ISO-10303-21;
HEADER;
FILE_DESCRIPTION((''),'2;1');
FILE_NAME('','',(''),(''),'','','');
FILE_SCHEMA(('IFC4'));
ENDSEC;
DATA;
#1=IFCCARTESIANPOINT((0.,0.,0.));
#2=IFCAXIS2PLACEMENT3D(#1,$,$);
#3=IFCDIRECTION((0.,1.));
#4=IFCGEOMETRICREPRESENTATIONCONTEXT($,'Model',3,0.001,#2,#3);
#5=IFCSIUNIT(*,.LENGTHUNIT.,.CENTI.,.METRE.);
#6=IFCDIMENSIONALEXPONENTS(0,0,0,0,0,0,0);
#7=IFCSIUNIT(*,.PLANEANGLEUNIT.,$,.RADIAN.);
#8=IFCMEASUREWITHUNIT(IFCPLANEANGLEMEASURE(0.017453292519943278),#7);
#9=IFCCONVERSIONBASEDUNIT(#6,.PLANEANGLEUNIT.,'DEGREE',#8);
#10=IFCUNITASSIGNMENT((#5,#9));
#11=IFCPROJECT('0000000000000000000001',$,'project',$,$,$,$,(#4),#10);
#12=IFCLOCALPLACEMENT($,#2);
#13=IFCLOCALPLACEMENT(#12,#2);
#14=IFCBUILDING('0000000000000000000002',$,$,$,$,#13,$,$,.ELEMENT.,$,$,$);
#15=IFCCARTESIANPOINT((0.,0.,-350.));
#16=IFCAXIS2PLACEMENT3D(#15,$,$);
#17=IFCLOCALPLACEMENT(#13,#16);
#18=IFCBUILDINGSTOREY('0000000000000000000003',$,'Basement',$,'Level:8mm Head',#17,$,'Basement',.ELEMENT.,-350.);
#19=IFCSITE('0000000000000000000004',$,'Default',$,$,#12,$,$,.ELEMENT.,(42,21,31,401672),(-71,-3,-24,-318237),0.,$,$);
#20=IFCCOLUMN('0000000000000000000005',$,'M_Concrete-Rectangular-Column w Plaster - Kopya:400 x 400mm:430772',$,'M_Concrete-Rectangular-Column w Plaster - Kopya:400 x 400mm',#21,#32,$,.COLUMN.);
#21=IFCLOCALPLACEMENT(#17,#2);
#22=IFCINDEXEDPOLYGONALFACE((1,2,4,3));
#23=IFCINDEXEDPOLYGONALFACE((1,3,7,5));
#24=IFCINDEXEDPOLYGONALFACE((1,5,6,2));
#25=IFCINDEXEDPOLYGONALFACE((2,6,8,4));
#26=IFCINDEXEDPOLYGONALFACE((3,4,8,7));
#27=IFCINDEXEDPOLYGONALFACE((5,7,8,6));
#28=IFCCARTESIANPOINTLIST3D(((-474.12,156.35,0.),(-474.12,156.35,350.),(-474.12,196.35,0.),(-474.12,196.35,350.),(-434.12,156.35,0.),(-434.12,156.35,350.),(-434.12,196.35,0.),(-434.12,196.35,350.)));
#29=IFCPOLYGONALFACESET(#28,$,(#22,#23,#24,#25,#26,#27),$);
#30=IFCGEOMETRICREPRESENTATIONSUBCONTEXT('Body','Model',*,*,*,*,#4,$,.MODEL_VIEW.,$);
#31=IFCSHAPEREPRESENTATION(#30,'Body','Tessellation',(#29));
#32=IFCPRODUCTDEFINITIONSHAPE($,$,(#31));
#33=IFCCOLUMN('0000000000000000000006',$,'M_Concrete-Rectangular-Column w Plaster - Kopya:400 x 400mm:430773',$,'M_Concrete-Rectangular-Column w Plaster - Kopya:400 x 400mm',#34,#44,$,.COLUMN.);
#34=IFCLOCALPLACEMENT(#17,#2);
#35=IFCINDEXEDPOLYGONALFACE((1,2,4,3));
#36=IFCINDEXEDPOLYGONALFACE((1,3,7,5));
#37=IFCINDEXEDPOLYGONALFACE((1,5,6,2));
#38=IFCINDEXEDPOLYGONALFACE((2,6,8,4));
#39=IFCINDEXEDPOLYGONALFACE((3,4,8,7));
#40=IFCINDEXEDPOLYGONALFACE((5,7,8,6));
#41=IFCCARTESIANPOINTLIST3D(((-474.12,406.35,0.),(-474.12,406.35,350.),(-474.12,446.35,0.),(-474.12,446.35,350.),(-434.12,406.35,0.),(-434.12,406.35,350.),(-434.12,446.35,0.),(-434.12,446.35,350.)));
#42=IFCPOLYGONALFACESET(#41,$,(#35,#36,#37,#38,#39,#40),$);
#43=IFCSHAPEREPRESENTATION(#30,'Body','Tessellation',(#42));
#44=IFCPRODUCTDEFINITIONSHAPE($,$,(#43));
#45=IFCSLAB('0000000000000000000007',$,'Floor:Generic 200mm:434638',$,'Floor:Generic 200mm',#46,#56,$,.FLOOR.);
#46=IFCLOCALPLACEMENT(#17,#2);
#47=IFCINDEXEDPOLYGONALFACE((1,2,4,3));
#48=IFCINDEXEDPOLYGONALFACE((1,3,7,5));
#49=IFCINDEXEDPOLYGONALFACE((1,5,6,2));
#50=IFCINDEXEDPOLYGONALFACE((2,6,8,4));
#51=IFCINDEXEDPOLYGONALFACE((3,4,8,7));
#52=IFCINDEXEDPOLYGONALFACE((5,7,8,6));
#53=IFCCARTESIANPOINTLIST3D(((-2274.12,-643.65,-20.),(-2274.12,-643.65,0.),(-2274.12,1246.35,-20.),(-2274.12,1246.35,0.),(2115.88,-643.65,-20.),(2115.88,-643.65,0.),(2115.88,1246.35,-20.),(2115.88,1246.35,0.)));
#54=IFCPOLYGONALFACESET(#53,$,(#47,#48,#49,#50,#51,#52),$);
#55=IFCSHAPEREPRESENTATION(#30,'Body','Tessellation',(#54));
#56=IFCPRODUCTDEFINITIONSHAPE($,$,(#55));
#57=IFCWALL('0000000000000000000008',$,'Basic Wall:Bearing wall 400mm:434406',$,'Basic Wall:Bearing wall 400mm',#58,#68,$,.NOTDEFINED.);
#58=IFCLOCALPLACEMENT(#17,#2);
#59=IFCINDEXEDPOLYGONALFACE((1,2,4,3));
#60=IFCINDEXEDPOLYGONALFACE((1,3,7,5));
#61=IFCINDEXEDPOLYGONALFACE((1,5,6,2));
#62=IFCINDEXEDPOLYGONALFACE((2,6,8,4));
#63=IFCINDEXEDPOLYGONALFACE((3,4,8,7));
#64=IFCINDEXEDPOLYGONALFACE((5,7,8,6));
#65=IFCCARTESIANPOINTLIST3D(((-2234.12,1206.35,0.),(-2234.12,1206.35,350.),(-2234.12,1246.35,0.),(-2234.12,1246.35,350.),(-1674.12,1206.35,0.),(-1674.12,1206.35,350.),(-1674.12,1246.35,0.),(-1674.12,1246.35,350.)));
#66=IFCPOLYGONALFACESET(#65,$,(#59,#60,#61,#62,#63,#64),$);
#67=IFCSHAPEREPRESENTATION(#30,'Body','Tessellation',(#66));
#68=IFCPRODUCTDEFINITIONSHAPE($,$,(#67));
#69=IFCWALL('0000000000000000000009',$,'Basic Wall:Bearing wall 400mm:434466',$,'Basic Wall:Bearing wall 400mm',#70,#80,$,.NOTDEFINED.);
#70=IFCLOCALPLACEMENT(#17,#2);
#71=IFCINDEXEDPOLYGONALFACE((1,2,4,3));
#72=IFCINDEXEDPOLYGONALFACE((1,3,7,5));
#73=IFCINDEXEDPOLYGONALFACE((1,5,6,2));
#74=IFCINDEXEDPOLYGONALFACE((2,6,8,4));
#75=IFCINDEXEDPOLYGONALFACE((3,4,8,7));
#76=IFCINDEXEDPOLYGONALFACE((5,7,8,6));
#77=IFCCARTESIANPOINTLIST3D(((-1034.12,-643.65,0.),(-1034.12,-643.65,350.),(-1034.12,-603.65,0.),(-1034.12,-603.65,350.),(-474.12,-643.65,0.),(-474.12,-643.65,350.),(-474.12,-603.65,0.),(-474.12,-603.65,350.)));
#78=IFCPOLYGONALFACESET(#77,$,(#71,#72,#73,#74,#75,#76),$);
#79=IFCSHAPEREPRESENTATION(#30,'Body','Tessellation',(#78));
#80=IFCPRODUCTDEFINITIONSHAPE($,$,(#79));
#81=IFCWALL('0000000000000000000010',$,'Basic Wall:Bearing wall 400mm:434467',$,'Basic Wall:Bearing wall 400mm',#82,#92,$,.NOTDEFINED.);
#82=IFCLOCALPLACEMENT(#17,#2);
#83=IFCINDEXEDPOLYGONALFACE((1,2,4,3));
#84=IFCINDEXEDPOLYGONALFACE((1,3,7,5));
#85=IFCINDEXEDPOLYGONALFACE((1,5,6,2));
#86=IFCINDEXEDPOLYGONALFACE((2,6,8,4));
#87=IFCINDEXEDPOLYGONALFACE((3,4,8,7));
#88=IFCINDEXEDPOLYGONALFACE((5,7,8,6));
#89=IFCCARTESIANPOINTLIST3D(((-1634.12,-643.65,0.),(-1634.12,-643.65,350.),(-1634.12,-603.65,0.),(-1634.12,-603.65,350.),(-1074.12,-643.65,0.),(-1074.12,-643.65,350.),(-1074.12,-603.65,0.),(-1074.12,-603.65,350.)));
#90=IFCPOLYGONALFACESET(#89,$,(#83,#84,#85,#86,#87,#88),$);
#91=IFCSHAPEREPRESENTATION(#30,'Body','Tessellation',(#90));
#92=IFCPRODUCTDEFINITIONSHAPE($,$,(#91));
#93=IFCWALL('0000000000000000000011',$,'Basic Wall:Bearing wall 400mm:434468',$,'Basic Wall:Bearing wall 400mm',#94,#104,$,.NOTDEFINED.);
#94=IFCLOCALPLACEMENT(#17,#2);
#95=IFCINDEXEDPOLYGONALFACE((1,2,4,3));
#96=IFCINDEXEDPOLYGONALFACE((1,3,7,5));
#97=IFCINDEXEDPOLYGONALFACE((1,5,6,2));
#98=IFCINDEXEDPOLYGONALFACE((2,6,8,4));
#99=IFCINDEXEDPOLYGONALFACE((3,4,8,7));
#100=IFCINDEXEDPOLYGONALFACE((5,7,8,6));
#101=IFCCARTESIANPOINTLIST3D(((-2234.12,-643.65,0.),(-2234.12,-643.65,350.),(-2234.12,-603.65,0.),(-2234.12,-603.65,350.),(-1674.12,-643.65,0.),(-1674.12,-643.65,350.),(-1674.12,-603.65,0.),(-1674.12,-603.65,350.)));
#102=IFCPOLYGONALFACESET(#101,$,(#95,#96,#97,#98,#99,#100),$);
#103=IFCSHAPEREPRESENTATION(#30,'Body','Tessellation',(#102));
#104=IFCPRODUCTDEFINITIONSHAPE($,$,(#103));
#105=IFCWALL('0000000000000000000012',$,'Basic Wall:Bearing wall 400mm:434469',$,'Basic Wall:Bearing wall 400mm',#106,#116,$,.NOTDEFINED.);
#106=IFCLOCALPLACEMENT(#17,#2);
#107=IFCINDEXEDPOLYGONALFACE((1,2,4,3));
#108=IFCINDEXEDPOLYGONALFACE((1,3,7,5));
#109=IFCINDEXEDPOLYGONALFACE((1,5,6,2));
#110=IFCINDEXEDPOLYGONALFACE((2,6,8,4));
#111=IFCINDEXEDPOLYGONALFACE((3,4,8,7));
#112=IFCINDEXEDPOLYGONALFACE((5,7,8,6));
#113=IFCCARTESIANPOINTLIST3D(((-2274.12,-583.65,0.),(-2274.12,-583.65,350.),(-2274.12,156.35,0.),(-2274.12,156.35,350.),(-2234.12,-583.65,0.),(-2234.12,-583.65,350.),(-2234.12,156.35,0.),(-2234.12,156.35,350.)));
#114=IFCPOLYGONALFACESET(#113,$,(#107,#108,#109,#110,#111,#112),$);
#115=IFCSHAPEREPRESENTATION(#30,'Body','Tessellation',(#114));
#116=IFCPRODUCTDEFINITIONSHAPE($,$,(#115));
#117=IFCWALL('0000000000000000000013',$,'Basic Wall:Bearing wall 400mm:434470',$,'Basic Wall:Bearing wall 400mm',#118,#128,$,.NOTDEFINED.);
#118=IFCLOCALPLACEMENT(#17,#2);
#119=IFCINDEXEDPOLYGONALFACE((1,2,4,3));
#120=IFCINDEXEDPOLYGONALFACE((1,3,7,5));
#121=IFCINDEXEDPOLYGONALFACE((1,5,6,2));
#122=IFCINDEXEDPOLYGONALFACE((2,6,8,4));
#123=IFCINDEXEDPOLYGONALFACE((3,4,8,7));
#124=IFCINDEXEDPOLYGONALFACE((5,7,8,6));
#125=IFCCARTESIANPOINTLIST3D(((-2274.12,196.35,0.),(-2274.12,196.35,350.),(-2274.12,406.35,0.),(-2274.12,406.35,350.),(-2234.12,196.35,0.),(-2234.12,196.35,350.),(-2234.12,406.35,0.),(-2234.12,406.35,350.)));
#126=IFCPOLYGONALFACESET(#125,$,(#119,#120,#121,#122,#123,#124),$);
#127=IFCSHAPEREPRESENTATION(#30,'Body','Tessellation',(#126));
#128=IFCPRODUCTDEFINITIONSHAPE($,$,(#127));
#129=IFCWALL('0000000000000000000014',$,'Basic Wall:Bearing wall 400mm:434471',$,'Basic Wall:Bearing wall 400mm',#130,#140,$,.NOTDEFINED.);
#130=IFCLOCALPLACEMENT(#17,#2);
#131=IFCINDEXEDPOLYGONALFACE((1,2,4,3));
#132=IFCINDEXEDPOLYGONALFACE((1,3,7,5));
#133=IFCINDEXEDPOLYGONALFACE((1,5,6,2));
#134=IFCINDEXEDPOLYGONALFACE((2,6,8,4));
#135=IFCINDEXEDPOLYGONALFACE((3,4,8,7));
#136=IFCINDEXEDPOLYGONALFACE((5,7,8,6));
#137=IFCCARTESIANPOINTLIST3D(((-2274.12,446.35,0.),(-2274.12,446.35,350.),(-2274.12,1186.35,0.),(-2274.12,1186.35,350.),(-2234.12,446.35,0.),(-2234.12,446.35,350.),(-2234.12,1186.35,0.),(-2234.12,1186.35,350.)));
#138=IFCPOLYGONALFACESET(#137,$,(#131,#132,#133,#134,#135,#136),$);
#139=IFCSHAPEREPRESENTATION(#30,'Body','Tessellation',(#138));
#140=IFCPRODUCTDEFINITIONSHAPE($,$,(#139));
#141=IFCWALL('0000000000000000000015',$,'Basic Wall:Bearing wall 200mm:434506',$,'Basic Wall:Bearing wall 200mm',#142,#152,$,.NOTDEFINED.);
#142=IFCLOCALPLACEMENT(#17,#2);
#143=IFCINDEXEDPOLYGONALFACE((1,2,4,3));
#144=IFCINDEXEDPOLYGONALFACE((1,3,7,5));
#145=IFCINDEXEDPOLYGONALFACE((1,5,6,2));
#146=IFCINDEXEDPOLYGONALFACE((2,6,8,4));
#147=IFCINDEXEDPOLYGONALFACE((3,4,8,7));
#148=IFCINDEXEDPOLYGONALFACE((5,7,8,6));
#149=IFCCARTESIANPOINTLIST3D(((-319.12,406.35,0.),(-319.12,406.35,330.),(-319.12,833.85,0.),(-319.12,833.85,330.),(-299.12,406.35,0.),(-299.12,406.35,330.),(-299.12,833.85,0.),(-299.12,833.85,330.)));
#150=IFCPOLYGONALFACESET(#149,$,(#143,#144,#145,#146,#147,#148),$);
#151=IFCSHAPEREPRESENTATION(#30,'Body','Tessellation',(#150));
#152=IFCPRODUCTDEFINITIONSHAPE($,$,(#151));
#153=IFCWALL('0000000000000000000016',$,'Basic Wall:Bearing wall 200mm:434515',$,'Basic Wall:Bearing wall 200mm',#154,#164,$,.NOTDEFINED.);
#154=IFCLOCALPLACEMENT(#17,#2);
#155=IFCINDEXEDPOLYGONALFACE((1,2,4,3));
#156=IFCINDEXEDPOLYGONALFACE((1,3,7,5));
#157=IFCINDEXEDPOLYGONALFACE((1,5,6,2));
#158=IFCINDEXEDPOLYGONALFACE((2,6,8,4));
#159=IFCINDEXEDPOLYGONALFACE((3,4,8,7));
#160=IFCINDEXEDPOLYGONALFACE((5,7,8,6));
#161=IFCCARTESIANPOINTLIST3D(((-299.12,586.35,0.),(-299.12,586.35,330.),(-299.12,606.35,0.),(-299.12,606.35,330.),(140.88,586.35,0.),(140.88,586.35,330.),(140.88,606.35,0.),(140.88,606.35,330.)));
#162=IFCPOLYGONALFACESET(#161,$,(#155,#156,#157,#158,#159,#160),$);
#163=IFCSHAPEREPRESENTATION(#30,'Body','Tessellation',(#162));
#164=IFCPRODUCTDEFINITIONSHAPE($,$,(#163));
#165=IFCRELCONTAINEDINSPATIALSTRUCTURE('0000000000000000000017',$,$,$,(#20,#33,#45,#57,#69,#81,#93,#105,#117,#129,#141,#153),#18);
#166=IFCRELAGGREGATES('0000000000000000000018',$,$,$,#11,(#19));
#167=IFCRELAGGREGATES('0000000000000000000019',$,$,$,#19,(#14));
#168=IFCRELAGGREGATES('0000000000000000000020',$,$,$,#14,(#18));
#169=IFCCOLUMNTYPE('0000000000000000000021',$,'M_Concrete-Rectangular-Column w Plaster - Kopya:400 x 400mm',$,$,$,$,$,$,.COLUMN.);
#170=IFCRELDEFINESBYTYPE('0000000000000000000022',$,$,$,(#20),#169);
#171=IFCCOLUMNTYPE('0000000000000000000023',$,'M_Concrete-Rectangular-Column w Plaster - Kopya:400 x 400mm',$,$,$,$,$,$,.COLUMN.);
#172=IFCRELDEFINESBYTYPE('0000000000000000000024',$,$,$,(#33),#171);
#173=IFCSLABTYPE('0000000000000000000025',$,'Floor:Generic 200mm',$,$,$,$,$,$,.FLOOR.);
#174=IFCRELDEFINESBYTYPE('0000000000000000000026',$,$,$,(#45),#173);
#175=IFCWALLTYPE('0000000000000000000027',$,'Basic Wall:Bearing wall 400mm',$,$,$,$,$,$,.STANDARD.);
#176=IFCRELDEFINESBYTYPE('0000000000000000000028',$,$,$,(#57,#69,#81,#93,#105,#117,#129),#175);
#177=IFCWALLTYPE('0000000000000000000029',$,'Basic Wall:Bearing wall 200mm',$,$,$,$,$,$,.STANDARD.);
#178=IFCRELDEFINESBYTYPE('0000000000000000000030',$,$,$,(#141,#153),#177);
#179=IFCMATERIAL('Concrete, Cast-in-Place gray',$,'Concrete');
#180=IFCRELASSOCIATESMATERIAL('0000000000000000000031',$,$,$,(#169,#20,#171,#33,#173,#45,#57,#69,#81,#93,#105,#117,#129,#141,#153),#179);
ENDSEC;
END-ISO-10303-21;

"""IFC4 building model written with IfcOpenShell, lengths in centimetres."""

from ifc_helpers import new_model, entity, si_unit, converted_unit, direction, frame, origin, place, context, subcontext, project, spatial, indexed_curve, outline, extrude, source, transform, mapped, material, type_object, type_shapes, element, save


model = new_model("IFC4")

# Units and contexts
model_context = context("Model", 3, precision=0.001, world=origin(), true_north=direction((0.0, 1.0)))
body_context = subcontext(model_context, "Body", "Model", "MODEL_VIEW")
ifc_project = project(units=[si_unit("LENGTHUNIT", "METRE", prefix="CENTI"), converted_unit("PLANEANGLEUNIT", "DEGREE", entity("IfcPlaneAngleMeasure", 0.017453292519943278), si_unit("PLANEANGLEUNIT", "RADIAN"), dimensions=[0, 0, 0, 0, 0, 0, 0])], contexts=[model_context])

# Site, building, storey
site_placement = place(None, origin())
site = spatial("IfcSite", under=ifc_project, at=site_placement, Name="Default", CompositionType="ELEMENT", RefLatitude=(42, 21, 31, 401672), RefLongitude=(-71, -3, -24, -318237), RefElevation=0.0)
building_placement = place(site_placement, origin())
building = spatial("IfcBuilding", under=site, at=building_placement, CompositionType="ELEMENT")
storey_placement = place(building_placement, frame((0.0, 0.0, -350.0)))
storey = spatial("IfcBuildingStorey", under=building, at=storey_placement, Name="Basement", ObjectType="Level:8mm Head", LongName="Basement", CompositionType="ELEMENT", Elevation=-350.0)

# Columns
ifc_material_1 = material(Name="Concrete, Cast-in-Place gray", Category="Concrete")
column_type_1 = type_object("IfcColumnType", Name="M_Concrete-Rectangular-Column w Plaster - Kopya:400 x 400mm", PredefinedType="COLUMN", material=ifc_material_1)
shared_shape_1 = source(origin(), body_context, "Body", "SweptSolid", [
    extrude(outline(indexed_curve([(-20.0, -20.0), (20.0, -20.0), (20.0, 20.0), (-20.0, 20.0), (-20.0, -20.0)], self_intersect=False)), frame((-454.12, 176.35, -350.0), z_axis=(0.0, 0.0, 1.0), x_axis=(-1.0, 0.0, 0.0)), (0.0, 0.0, 1.0), 350.0),
])
type_shapes(column_type_1, [shared_shape_1])
column_1_placement = place(storey_placement, frame((0.0, 0.0, 350.0)))
element("IfcColumn", 1, at=column_1_placement, inside=storey, type_object=column_type_1, material=ifc_material_1, Name="M_Concrete-Rectangular-Column w Plaster - Kopya:400 x 400mm:430772", ObjectType="M_Concrete-Rectangular-Column w Plaster - Kopya:400 x 400mm", PredefinedType="COLUMN", context=body_context, shape_type="MappedRepresentation", body=[
    mapped(shared_shape_1, transform((0.0, 0.0, 0.0), scale=1.0)),
])
column_type_2 = type_object("IfcColumnType", Name="M_Concrete-Rectangular-Column w Plaster - Kopya:400 x 400mm", PredefinedType="COLUMN", material=ifc_material_1)
shared_shape_2 = source(origin(), body_context, "Body", "SweptSolid", [
    extrude(outline(indexed_curve([(-20.0, -20.0), (20.0, -20.0), (20.0, 20.0), (-20.0, 20.0), (-20.0, -20.0)], self_intersect=False)), frame((-454.12, 426.35, -350.0), z_axis=(0.0, 0.0, 1.0), x_axis=(-1.0, 0.0, 0.0)), (0.0, 0.0, 1.0), 350.0),
])
type_shapes(column_type_2, [shared_shape_2])
column_2_placement = place(storey_placement, frame((0.0, 0.0, 350.0)))
element("IfcColumn", 2, at=column_2_placement, inside=storey, type_object=column_type_2, material=ifc_material_1, Name="M_Concrete-Rectangular-Column w Plaster - Kopya:400 x 400mm:430773", ObjectType="M_Concrete-Rectangular-Column w Plaster - Kopya:400 x 400mm", PredefinedType="COLUMN", context=body_context, shape_type="MappedRepresentation", body=[
    mapped(shared_shape_2, transform((0.0, 0.0, 0.0), scale=1.0)),
])

# Slab
slab_type = type_object("IfcSlabType", Name="Floor:Generic 200mm", PredefinedType="FLOOR", material=ifc_material_1)
slab_placement = place(storey_placement, origin())
element("IfcSlab", 3, at=slab_placement, inside=storey, type_object=slab_type, material=ifc_material_1, Name="Floor:Generic 200mm:434638", ObjectType="Floor:Generic 200mm", PredefinedType="FLOOR", context=body_context, shape_type="SweptSolid", body=[
    extrude(outline(indexed_curve([(-945.0, -2195.0), (945.0, -2195.0), (945.0, 2195.0), (-945.0, 2195.0), (-945.0, -2195.0)], self_intersect=False)), frame((-79.12, 301.35, 0.0), z_axis=(0.0, 0.0, -1.0), x_axis=(0.0, 1.0, 0.0)), (0.0, 0.0, 1.0), 20.0),
])

# Walls
wall_type_1 = type_object("IfcWallType", Name="Basic Wall:Bearing wall 400mm", PredefinedType="STANDARD")
wall_1_placement = place(storey_placement, frame((-2234.12, 1226.35, 0.0)))
element("IfcWall", 4, at=wall_1_placement, inside=storey, type_object=wall_type_1, material=ifc_material_1, Name="Basic Wall:Bearing wall 400mm:434406", ObjectType="Basic Wall:Bearing wall 400mm", PredefinedType="NOTDEFINED", context=body_context, shape_type="SweptSolid", body=[
    extrude(outline(indexed_curve([(560.0, 20.0), (0.0, 20.0), (0.0, -20.0), (560.0, -20.0), (560.0, 20.0)], self_intersect=False)), origin(), (0.0, 0.0, 1.0), 350.0),
])
wall_2_placement = place(storey_placement, frame((-474.12, -623.65, 0.0), z_axis=(0.0, 0.0, 1.0), x_axis=(-1.0, 0.0, 0.0)))
element("IfcWall", 5, at=wall_2_placement, inside=storey, type_object=wall_type_1, material=ifc_material_1, Name="Basic Wall:Bearing wall 400mm:434466", ObjectType="Basic Wall:Bearing wall 400mm", PredefinedType="NOTDEFINED", context=body_context, shape_type="SweptSolid", body=[
    extrude(outline(indexed_curve([(560.0, 20.0), (0.0, 20.0), (0.0, -20.0), (560.0, -20.0), (560.0, 20.0)], self_intersect=False)), origin(), (0.0, 0.0, 1.0), 350.0),
])
wall_3_placement = place(storey_placement, frame((-1074.12, -623.65, 0.0), z_axis=(0.0, 0.0, 1.0), x_axis=(-1.0, 0.0, 0.0)))
element("IfcWall", 6, at=wall_3_placement, inside=storey, type_object=wall_type_1, material=ifc_material_1, Name="Basic Wall:Bearing wall 400mm:434467", ObjectType="Basic Wall:Bearing wall 400mm", PredefinedType="NOTDEFINED", context=body_context, shape_type="SweptSolid", body=[
    extrude(outline(indexed_curve([(560.0, 20.0), (0.0, 20.0), (0.0, -20.0), (560.0, -20.0), (560.0, 20.0)], self_intersect=False)), origin(), (0.0, 0.0, 1.0), 350.0),
])
wall_4_placement = place(storey_placement, frame((-1674.12, -623.65, 0.0), z_axis=(0.0, 0.0, 1.0), x_axis=(-1.0, 0.0, 0.0)))
element("IfcWall", 7, at=wall_4_placement, inside=storey, type_object=wall_type_1, material=ifc_material_1, Name="Basic Wall:Bearing wall 400mm:434468", ObjectType="Basic Wall:Bearing wall 400mm", PredefinedType="NOTDEFINED", context=body_context, shape_type="SweptSolid", body=[
    extrude(outline(indexed_curve([(560.0, 20.0), (0.0, 20.0), (0.0, -20.0), (560.0, -20.0), (560.0, 20.0)], self_intersect=False)), origin(), (0.0, 0.0, 1.0), 350.0),
])
wall_5_placement = place(storey_placement, frame((-2254.12, -583.65, 0.0), z_axis=(0.0, 0.0, 1.0), x_axis=(0.0, 1.0, 0.0)))
element("IfcWall", 8, at=wall_5_placement, inside=storey, type_object=wall_type_1, material=ifc_material_1, Name="Basic Wall:Bearing wall 400mm:434469", ObjectType="Basic Wall:Bearing wall 400mm", PredefinedType="NOTDEFINED", context=body_context, shape_type="SweptSolid", body=[
    extrude(outline(indexed_curve([(740.0, 20.0), (0.0, 20.0), (0.0, -20.0), (740.0, -20.0), (740.0, 20.0)], self_intersect=False)), origin(), (0.0, 0.0, 1.0), 350.0),
])
wall_6_placement = place(storey_placement, frame((-2254.12, 196.35, 0.0), z_axis=(0.0, 0.0, 1.0), x_axis=(0.0, 1.0, 0.0)))
element("IfcWall", 9, at=wall_6_placement, inside=storey, type_object=wall_type_1, material=ifc_material_1, Name="Basic Wall:Bearing wall 400mm:434470", ObjectType="Basic Wall:Bearing wall 400mm", PredefinedType="NOTDEFINED", context=body_context, shape_type="SweptSolid", body=[
    extrude(outline(indexed_curve([(210.0, 20.0), (0.0, 20.0), (0.0, -20.0), (210.0, -20.0), (210.0, 20.0)], self_intersect=False)), origin(), (0.0, 0.0, 1.0), 350.0),
])
wall_7_placement = place(storey_placement, frame((-2254.12, 1186.35, 0.0), z_axis=(0.0, 0.0, 1.0), x_axis=(0.0, -1.0, 0.0)))
element("IfcWall", 10, at=wall_7_placement, inside=storey, type_object=wall_type_1, material=ifc_material_1, Name="Basic Wall:Bearing wall 400mm:434471", ObjectType="Basic Wall:Bearing wall 400mm", PredefinedType="NOTDEFINED", context=body_context, shape_type="SweptSolid", body=[
    extrude(outline(indexed_curve([(740.0, 20.0), (0.0, 20.0), (0.0, -20.0), (740.0, -20.0), (740.0, 20.0)], self_intersect=False)), origin(), (0.0, 0.0, 1.0), 350.0),
])
wall_type_2 = type_object("IfcWallType", Name="Basic Wall:Bearing wall 200mm", PredefinedType="STANDARD")
wall_8_placement = place(storey_placement, frame((-309.12, 833.85, 0.0), z_axis=(0.0, 0.0, 1.0), x_axis=(0.0, -1.0, 0.0)))
element("IfcWall", 11, at=wall_8_placement, inside=storey, type_object=wall_type_2, material=ifc_material_1, Name="Basic Wall:Bearing wall 200mm:434506", ObjectType="Basic Wall:Bearing wall 200mm", PredefinedType="NOTDEFINED", context=body_context, shape_type="SweptSolid", body=[
    extrude(outline(indexed_curve([(427.5, 10.0), (0.0, 10.0), (0.0, -10.0), (427.5, -10.0), (427.5, 10.0)], self_intersect=False)), origin(), (0.0, 0.0, 1.0), 330.0),
])
wall_9_placement = place(storey_placement, frame((-299.12, 596.35, 0.0)))
element("IfcWall", 12, at=wall_9_placement, inside=storey, type_object=wall_type_2, material=ifc_material_1, Name="Basic Wall:Bearing wall 200mm:434515", ObjectType="Basic Wall:Bearing wall 200mm", PredefinedType="NOTDEFINED", context=body_context, shape_type="SweptSolid", body=[
    extrude(outline(indexed_curve([(440.0, 10.0), (0.0, 10.0), (0.0, -10.0), (440.0, -10.0), (440.0, 10.0)], self_intersect=False)), origin(), (0.0, 0.0, 1.0), 330.0),
])

save(model, "model.ifc")
